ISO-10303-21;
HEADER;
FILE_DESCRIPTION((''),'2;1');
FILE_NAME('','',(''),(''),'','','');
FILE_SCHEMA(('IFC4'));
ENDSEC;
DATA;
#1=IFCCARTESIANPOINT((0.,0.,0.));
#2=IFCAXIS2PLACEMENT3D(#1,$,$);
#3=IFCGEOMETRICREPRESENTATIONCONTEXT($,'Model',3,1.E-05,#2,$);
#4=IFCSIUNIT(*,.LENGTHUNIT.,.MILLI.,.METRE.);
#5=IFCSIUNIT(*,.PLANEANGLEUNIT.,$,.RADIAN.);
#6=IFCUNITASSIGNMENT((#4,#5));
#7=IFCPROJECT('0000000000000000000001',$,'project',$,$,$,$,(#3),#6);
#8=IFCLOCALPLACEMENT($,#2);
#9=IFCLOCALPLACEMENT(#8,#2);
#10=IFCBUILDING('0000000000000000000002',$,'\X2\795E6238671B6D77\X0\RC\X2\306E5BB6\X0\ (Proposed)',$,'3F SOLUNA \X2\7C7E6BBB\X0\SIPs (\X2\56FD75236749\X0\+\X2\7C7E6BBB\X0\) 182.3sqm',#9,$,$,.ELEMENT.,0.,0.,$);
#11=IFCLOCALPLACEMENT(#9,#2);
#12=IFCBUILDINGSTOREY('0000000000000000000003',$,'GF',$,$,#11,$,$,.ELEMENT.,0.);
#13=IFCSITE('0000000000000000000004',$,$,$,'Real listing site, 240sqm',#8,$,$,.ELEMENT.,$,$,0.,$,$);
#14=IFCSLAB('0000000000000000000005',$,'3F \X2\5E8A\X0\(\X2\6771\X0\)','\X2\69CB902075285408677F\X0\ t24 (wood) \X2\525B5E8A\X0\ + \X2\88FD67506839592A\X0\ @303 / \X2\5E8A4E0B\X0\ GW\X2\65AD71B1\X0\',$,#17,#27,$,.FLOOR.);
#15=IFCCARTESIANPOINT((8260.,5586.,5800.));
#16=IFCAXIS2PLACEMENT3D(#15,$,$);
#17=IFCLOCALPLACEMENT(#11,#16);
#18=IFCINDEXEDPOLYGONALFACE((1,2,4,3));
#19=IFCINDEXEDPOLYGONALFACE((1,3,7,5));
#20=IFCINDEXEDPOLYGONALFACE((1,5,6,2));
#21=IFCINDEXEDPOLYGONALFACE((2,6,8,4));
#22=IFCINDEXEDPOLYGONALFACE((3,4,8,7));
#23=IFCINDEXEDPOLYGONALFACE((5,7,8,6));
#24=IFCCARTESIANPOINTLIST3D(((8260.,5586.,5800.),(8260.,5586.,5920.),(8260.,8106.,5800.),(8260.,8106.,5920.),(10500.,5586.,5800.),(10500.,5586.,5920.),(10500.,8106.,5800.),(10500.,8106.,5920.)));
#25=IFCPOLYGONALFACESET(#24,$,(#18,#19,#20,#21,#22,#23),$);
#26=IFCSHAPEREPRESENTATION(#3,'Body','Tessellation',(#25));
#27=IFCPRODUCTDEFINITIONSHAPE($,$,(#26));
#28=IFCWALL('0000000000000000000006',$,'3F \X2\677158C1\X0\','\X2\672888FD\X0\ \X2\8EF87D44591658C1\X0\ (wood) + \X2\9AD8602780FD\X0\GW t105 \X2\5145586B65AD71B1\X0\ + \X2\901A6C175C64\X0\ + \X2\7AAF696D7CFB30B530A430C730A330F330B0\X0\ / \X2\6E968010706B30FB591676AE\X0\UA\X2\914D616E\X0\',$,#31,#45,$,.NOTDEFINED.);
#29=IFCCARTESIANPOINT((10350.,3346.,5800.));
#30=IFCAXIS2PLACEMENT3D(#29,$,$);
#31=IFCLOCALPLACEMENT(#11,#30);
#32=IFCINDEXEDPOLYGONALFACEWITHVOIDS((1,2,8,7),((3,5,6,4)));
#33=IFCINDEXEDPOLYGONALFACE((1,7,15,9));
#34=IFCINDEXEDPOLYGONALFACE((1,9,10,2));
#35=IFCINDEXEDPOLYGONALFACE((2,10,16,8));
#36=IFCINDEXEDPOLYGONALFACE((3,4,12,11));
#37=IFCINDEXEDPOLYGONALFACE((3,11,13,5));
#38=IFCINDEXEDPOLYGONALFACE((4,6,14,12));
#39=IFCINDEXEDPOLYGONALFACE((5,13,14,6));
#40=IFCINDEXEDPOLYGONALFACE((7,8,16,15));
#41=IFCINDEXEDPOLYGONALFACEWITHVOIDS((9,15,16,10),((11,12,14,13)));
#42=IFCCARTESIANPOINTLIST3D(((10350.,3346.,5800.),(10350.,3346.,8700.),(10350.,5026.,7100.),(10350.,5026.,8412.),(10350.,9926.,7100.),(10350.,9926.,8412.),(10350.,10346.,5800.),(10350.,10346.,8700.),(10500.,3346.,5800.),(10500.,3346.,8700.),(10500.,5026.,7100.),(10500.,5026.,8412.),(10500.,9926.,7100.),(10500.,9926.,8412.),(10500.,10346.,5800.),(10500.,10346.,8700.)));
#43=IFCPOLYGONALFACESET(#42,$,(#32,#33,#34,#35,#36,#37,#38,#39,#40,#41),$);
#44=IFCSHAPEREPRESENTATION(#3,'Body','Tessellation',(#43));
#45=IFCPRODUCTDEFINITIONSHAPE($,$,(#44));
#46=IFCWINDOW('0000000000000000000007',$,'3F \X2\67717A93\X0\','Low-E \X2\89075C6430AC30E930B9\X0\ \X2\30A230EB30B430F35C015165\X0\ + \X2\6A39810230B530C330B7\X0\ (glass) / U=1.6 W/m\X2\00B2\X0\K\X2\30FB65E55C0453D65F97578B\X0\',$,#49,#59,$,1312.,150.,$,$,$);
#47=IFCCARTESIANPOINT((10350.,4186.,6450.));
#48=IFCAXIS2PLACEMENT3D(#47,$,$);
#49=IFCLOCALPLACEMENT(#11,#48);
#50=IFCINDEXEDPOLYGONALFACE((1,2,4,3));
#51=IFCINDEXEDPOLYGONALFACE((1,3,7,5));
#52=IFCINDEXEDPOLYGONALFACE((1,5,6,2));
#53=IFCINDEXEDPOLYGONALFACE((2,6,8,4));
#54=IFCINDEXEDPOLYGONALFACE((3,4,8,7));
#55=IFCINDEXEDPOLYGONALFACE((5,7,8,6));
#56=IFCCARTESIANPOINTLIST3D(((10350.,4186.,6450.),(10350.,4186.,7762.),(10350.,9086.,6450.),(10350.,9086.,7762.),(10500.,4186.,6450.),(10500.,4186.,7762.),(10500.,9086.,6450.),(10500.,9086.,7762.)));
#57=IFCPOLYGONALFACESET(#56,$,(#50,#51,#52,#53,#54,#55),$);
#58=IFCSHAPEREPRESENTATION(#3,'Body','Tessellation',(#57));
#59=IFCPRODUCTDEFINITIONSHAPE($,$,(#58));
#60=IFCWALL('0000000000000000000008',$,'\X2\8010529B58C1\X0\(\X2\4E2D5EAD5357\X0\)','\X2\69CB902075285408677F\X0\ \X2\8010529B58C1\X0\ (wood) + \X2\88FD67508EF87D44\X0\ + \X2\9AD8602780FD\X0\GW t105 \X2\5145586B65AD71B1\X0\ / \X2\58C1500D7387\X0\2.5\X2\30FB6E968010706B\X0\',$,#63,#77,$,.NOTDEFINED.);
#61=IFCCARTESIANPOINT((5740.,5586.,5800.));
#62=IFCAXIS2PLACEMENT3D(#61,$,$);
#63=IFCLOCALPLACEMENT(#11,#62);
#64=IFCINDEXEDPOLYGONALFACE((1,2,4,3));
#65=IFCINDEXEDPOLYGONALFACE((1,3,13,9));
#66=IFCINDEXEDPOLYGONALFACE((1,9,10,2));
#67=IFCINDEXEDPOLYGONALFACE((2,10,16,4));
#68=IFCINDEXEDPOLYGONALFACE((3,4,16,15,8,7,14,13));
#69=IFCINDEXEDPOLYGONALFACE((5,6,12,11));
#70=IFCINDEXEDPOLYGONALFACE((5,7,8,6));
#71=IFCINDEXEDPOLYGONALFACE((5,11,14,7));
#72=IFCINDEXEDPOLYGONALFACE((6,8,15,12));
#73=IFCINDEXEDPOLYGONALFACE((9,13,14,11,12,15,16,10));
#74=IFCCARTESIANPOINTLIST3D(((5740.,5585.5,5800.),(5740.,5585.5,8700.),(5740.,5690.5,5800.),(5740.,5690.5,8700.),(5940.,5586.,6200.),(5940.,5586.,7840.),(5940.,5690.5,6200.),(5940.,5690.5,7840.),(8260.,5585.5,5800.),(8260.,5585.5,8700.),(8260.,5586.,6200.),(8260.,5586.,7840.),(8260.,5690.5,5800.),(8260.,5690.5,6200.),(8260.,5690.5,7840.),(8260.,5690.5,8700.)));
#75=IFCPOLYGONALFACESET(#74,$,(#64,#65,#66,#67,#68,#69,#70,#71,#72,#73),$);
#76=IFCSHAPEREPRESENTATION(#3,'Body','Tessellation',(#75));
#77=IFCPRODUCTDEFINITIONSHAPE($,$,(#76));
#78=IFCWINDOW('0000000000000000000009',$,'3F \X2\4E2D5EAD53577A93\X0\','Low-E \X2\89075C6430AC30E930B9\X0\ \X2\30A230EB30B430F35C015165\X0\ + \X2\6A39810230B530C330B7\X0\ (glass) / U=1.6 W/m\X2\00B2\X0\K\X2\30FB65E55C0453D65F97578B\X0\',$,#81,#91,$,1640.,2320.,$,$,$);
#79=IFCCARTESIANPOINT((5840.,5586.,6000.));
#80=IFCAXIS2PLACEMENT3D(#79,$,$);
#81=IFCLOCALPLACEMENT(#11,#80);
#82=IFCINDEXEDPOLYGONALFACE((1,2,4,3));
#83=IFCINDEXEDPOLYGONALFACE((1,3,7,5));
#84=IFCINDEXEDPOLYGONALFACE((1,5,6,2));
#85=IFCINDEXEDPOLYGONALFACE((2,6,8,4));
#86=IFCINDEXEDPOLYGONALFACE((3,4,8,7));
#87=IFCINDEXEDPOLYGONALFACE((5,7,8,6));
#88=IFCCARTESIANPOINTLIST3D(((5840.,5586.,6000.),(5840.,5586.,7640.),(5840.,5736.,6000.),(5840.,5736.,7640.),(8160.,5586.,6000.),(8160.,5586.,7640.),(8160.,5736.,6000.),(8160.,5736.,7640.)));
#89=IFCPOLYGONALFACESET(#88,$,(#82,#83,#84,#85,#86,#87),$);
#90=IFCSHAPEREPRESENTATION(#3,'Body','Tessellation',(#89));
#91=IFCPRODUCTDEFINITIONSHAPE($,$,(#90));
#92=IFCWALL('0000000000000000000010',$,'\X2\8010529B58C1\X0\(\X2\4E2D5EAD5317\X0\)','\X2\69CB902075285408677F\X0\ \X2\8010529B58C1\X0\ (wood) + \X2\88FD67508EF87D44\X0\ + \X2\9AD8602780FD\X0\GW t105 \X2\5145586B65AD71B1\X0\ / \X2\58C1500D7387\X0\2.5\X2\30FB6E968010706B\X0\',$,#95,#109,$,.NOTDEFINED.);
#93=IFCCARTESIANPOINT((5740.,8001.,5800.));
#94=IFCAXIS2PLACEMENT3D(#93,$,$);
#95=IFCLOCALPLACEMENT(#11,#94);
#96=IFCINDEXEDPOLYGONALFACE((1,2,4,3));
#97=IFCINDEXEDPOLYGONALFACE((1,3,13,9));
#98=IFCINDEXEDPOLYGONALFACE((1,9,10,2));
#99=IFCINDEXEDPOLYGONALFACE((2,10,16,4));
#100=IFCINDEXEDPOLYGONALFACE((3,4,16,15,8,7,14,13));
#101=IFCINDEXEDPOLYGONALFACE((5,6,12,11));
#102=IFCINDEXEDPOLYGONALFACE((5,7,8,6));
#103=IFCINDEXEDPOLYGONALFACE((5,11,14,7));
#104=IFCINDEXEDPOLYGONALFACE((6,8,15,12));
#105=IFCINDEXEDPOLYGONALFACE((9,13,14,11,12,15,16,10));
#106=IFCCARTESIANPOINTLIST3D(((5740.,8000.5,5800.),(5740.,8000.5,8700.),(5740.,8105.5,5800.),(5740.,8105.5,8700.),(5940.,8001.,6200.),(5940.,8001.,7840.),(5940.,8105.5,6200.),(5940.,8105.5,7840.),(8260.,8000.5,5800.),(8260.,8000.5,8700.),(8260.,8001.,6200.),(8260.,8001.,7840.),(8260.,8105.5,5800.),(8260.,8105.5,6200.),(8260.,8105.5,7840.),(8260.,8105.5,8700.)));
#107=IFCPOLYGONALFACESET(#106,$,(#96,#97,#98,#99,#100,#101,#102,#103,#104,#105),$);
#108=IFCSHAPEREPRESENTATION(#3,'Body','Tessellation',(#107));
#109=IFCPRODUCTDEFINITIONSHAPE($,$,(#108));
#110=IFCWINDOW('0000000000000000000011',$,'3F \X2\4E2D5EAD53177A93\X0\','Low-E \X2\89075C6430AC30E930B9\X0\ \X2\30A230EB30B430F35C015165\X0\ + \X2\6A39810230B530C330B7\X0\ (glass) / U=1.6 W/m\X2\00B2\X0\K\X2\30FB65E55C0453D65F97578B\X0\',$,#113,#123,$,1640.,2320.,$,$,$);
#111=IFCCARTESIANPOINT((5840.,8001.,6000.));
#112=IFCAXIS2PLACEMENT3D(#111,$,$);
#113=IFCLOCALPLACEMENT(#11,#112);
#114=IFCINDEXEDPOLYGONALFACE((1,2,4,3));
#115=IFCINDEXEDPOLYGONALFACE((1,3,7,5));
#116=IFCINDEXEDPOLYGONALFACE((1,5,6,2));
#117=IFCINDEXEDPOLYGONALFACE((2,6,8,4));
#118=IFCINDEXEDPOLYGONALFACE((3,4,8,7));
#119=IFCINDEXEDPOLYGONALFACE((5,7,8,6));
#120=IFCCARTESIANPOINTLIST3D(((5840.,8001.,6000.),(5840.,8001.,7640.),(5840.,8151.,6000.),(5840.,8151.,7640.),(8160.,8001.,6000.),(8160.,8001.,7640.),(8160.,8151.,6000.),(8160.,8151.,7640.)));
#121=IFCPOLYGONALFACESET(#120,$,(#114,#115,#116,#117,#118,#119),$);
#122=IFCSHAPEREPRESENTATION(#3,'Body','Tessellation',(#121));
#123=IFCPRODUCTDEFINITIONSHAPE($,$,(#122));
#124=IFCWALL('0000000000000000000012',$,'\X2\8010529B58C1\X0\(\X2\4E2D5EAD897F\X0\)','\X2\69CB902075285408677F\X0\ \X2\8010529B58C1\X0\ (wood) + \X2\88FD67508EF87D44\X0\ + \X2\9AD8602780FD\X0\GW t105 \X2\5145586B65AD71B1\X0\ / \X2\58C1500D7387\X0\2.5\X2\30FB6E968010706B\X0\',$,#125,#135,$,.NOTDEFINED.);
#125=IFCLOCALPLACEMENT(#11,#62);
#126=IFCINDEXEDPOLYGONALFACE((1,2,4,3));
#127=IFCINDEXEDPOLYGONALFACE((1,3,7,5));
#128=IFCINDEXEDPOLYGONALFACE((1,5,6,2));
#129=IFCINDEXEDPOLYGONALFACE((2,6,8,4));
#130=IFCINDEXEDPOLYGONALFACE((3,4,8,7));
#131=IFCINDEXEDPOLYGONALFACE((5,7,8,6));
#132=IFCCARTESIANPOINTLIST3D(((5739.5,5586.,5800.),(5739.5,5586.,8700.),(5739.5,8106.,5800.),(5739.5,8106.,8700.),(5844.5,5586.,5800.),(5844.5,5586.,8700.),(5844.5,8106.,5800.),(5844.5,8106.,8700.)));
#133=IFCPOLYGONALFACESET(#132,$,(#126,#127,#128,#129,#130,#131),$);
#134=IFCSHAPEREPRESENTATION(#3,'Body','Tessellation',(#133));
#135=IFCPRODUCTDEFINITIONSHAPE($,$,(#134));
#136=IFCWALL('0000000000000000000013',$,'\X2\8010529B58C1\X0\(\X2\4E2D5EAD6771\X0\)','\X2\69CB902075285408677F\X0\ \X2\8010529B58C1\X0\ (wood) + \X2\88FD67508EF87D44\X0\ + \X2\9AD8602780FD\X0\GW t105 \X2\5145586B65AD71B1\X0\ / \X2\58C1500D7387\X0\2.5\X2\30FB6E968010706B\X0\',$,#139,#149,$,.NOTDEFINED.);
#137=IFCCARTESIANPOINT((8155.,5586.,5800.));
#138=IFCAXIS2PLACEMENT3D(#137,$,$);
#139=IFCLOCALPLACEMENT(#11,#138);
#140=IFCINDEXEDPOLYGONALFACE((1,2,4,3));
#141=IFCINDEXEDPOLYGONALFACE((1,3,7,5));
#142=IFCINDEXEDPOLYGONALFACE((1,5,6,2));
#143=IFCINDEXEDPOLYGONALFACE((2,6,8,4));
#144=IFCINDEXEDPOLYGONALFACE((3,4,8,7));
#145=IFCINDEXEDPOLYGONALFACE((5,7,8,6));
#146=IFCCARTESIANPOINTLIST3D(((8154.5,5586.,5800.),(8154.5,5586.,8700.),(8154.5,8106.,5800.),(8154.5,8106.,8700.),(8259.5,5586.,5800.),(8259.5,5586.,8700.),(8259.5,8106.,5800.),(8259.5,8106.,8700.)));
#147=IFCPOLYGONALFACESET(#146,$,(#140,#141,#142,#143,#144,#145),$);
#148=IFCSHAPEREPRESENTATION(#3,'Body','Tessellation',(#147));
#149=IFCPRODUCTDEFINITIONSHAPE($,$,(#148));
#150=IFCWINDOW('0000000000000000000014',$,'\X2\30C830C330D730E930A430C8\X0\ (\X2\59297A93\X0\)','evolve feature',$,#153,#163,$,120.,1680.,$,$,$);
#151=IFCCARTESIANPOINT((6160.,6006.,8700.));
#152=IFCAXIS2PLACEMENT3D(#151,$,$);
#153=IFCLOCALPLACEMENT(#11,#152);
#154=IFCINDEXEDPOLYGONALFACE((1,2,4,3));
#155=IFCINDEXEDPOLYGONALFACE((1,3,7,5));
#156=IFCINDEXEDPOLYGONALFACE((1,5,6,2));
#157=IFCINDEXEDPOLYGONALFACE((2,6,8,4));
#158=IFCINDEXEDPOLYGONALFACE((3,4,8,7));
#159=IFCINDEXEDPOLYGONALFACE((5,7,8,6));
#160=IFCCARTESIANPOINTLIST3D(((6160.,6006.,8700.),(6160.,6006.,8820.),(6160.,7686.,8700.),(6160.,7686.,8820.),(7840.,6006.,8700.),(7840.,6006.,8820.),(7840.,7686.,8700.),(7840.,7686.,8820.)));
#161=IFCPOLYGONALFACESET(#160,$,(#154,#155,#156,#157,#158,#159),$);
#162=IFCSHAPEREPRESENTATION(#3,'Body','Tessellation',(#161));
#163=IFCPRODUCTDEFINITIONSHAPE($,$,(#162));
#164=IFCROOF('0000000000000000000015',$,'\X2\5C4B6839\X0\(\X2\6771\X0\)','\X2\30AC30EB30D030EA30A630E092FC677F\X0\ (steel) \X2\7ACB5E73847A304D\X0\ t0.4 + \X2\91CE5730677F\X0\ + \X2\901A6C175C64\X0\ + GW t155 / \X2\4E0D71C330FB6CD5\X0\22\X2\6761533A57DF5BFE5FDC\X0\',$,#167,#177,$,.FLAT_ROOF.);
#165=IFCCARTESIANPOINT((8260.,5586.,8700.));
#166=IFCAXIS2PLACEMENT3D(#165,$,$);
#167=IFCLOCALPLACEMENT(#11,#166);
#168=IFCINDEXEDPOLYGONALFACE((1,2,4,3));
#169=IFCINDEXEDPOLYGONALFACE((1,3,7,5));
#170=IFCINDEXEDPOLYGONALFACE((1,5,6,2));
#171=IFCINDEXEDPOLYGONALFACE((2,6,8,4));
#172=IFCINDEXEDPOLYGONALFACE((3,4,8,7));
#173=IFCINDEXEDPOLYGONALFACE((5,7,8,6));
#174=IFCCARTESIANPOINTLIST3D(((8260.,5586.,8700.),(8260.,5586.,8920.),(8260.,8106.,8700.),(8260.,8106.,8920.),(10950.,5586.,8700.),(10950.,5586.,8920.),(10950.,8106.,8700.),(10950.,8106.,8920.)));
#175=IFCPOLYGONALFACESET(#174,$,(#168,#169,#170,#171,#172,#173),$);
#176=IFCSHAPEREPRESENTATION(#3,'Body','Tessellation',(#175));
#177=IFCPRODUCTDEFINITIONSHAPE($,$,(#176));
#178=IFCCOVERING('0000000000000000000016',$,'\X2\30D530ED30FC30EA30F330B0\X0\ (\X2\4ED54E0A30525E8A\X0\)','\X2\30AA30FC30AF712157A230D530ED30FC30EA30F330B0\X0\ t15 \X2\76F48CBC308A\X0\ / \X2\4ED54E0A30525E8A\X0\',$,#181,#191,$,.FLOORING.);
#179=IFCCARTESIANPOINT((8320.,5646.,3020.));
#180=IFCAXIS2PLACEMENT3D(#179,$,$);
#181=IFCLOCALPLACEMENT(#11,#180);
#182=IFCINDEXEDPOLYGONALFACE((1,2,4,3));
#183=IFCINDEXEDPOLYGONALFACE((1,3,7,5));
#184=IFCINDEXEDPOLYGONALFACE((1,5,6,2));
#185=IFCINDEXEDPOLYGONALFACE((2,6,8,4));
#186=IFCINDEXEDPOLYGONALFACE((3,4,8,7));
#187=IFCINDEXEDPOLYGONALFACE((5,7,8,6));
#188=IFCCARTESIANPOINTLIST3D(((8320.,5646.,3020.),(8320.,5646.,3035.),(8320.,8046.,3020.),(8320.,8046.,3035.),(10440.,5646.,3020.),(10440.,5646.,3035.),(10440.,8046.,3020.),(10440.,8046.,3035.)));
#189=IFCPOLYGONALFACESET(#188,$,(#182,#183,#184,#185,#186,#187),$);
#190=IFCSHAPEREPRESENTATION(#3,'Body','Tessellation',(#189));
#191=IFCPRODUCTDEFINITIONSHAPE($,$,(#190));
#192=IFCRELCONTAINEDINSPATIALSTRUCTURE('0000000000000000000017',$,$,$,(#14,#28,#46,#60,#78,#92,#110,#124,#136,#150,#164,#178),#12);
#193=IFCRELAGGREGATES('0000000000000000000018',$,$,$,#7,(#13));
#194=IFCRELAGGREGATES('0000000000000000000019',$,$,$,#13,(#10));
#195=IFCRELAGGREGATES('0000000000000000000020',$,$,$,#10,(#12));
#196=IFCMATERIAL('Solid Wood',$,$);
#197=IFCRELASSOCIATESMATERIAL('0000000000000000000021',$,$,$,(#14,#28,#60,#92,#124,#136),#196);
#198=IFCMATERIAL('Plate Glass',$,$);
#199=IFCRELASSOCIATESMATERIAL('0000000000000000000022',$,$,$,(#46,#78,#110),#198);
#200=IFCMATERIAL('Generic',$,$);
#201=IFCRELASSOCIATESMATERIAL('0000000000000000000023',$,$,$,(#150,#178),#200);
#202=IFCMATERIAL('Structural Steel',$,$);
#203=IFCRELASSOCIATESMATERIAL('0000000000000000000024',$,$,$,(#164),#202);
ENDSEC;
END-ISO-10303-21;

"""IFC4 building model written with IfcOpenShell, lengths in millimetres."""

from ifc_helpers import new_model, si_unit, frame, frame_2d, origin, place, context, project, spatial, rectangle, extrude, material, element, fill, save


model = new_model("IFC4")

# Units and contexts
model_context = context("Model", 3, precision=1e-05, world=origin())
ifc_project = project(units=[si_unit("LENGTHUNIT", "METRE", prefix="MILLI"), si_unit("PLANEANGLEUNIT", "RADIAN")], contexts=[model_context])

# Site, building, storey
site_placement = place(None, origin())
site = spatial("IfcSite", under=ifc_project, at=site_placement, ObjectType="Real listing site, 240sqm", CompositionType="ELEMENT", RefElevation=0.0)
building_placement = place(site_placement, origin())
building = spatial("IfcBuilding", under=site, at=building_placement, Name="神戸望海RCの家 (Proposed)", ObjectType="3F SOLUNA 籾殻SIPs (国産杉+籾殻) 182.3sqm", CompositionType="ELEMENT", ElevationOfRefHeight=0.0, ElevationOfTerrain=0.0)
storey_placement = place(building_placement, origin())
storey = spatial("IfcBuildingStorey", under=building, at=storey_placement, Name="GF", CompositionType="ELEMENT", Elevation=0.0)

# Slab
ifc_material_1 = material(Name="Solid Wood")
slab_placement = place(storey_placement, frame((8260.0, 5586.0, 5800.0)))
element("IfcSlab", 1, at=slab_placement, inside=storey, material=ifc_material_1, Name="3F 床(東)", Description="構造用合板 t24 (wood) 剛床 + 製材根太 @303 / 床下 GW断熱", PredefinedType="FLOOR", context=model_context, shape_type="SweptSolid", body=[
    extrude(rectangle(XDim=2240.0, YDim=2520.0, at=frame_2d((1120.0, 1260.0))), frame((8260.0, 5586.0, 5800.0)), (0.0, 0.0, 1.0), 120.0),
])

# Walls, openings, windows
wall_1_placement = place(storey_placement, frame((10350.0, 3346.0, 5800.0)))
wall_1 = element("IfcWall", 2, at=wall_1_placement, inside=storey, material=ifc_material_1, Name="3F 東壁", Description="木製 軸組外壁 (wood) + 高性能GW t105 充填断熱 + 通気層 + 窯業系サイディング / 準耐火・外皮UA配慮", PredefinedType="NOTDEFINED", context=model_context, shape_type="SweptSolid", body=[
    extrude(rectangle(XDim=150.0, YDim=7000.0, at=frame_2d((75.0, 3500.0))), frame((10350.0, 3346.0, 5800.0)), (0.0, 0.0, 1.0), 2900.0),
])
opening_1_placement = place(storey_placement, frame((10350.0, 4186.0, 6450.0)))
opening_1 = element("IfcOpeningElement", 3, at=opening_1_placement, cuts=wall_1, PredefinedType="NOTDEFINED", context=model_context, shape_type="SweptSolid", body=[
    extrude(rectangle(XDim=150.0, YDim=4900.0, at=frame_2d((75.0, 2450.0))), frame((10350.0, 4186.0, 6450.0)), (0.0, 0.0, 1.0), 1312.0),
])
ifc_material_2 = material(Name="Plate Glass")
window_1_placement = place(storey_placement, frame((10350.0, 4186.0, 6450.0)))
window_1 = element("IfcWindow", 4, at=window_1_placement, inside=storey, material=ifc_material_2, Name="3F 東窓", Description="Low-E 複層ガラス アルゴン封入 + 樹脂サッシ (glass) / U=1.6 W/m²K・日射取得型", OverallHeight=1312.0, OverallWidth=150.0, context=model_context, shape_type="SweptSolid", body=[
    extrude(rectangle(XDim=150.0, YDim=4900.0, at=frame_2d((75.0, 2450.0))), frame((10350.0, 4186.0, 6450.0)), (0.0, 0.0, 1.0), 1312.0),
])
fill(opening_1, window_1)
wall_2_placement = place(storey_placement, frame((5740.0, 5586.0, 5800.0)))
wall_2 = element("IfcWall", 5, at=wall_2_placement, inside=storey, material=ifc_material_1, Name="耐力壁(中庭南)", Description="構造用合板 耐力壁 (wood) + 製材軸組 + 高性能GW t105 充填断熱 / 壁倍率2.5・準耐火", PredefinedType="NOTDEFINED", context=model_context, shape_type="SweptSolid", body=[
    extrude(rectangle(XDim=2520.0, YDim=105.0, at=frame_2d((1260.0, 52.0))), frame((5740.0, 5586.0, 5800.0)), (0.0, 0.0, 1.0), 2900.0),
])
opening_2_placement = place(storey_placement, frame((5840.0, 5586.0, 6000.0)))
opening_2 = element("IfcOpeningElement", 6, at=opening_2_placement, cuts=wall_2, PredefinedType="NOTDEFINED", context=model_context, shape_type="SweptSolid", body=[
    extrude(rectangle(XDim=2320.0, YDim=150.0, at=frame_2d((1160.0, 75.0))), frame((5840.0, 5586.0, 6000.0)), (0.0, 0.0, 1.0), 1640.0),
])
window_2_placement = place(storey_placement, frame((5840.0, 5586.0, 6000.0)))
window_2 = element("IfcWindow", 7, at=window_2_placement, inside=storey, material=ifc_material_2, Name="3F 中庭南窓", Description="Low-E 複層ガラス アルゴン封入 + 樹脂サッシ (glass) / U=1.6 W/m²K・日射取得型", OverallHeight=1640.0, OverallWidth=2320.0, context=model_context, shape_type="SweptSolid", body=[
    extrude(rectangle(XDim=2320.0, YDim=150.0, at=frame_2d((1160.0, 75.0))), frame((5840.0, 5586.0, 6000.0)), (0.0, 0.0, 1.0), 1640.0),
])
fill(opening_2, window_2)
wall_3_placement = place(storey_placement, frame((5740.0, 8001.0, 5800.0)))
wall_3 = element("IfcWall", 8, at=wall_3_placement, inside=storey, material=ifc_material_1, Name="耐力壁(中庭北)", Description="構造用合板 耐力壁 (wood) + 製材軸組 + 高性能GW t105 充填断熱 / 壁倍率2.5・準耐火", PredefinedType="NOTDEFINED", context=model_context, shape_type="SweptSolid", body=[
    extrude(rectangle(XDim=2520.0, YDim=105.0, at=frame_2d((1260.0, 52.0))), frame((5740.0, 8001.0, 5800.0)), (0.0, 0.0, 1.0), 2900.0),
])
opening_3_placement = place(storey_placement, frame((5840.0, 8001.0, 6000.0)))
opening_3 = element("IfcOpeningElement", 9, at=opening_3_placement, cuts=wall_3, PredefinedType="NOTDEFINED", context=model_context, shape_type="SweptSolid", body=[
    extrude(rectangle(XDim=2320.0, YDim=150.0, at=frame_2d((1160.0, 75.0))), frame((5840.0, 8001.0, 6000.0)), (0.0, 0.0, 1.0), 1640.0),
])
window_3_placement = place(storey_placement, frame((5840.0, 8001.0, 6000.0)))
window_3 = element("IfcWindow", 10, at=window_3_placement, inside=storey, material=ifc_material_2, Name="3F 中庭北窓", Description="Low-E 複層ガラス アルゴン封入 + 樹脂サッシ (glass) / U=1.6 W/m²K・日射取得型", OverallHeight=1640.0, OverallWidth=2320.0, context=model_context, shape_type="SweptSolid", body=[
    extrude(rectangle(XDim=2320.0, YDim=150.0, at=frame_2d((1160.0, 75.0))), frame((5840.0, 8001.0, 6000.0)), (0.0, 0.0, 1.0), 1640.0),
])
fill(opening_3, window_3)

# Walls
wall_4_placement = place(storey_placement, frame((5740.0, 5586.0, 5800.0)))
element("IfcWall", 11, at=wall_4_placement, inside=storey, material=ifc_material_1, Name="耐力壁(中庭西)", Description="構造用合板 耐力壁 (wood) + 製材軸組 + 高性能GW t105 充填断熱 / 壁倍率2.5・準耐火", PredefinedType="NOTDEFINED", context=model_context, shape_type="SweptSolid", body=[
    extrude(rectangle(XDim=105.0, YDim=2520.0, at=frame_2d((52.0, 1260.0))), frame((5740.0, 5586.0, 5800.0)), (0.0, 0.0, 1.0), 2900.0),
])
wall_5_placement = place(storey_placement, frame((8155.0, 5586.0, 5800.0)))
element("IfcWall", 12, at=wall_5_placement, inside=storey, material=ifc_material_1, Name="耐力壁(中庭東)", Description="構造用合板 耐力壁 (wood) + 製材軸組 + 高性能GW t105 充填断熱 / 壁倍率2.5・準耐火", PredefinedType="NOTDEFINED", context=model_context, shape_type="SweptSolid", body=[
    extrude(rectangle(XDim=105.0, YDim=2520.0, at=frame_2d((52.0, 1260.0))), frame((8155.0, 5586.0, 5800.0)), (0.0, 0.0, 1.0), 2900.0),
])

# Window
ifc_material_3 = material(Name="Generic")
window_4_placement = place(storey_placement, frame((6160.0, 6006.0, 8700.0)))
element("IfcWindow", 13, at=window_4_placement, inside=storey, material=ifc_material_3, Name="トップライト (天窓)", Description="evolve feature", OverallHeight=120.0, OverallWidth=1680.0, context=model_context, shape_type="SweptSolid", body=[
    extrude(rectangle(XDim=1680.0, YDim=1680.0, at=frame_2d((840.0, 840.0))), frame((6160.0, 6006.0, 8700.0)), (0.0, 0.0, 1.0), 120.0),
])

# Roof
ifc_material_4 = material(Name="Structural Steel")
for number, where, name in (
    (14, (8260.0, 5586.0, 8700.0), "屋根(東)"),
):
    element("IfcRoof", number, at=place(storey_placement, frame(where)), inside=storey, material=ifc_material_4, Name=name, Description="ガルバリウム鋼板 (steel) 立平葺き t0.4 + 野地板 + 通気層 + GW t155 / 不燃・法22条区域対応", PredefinedType="FLAT_ROOF", context=model_context, shape_type="SweptSolid", body=[
        extrude(rectangle(XDim=2690.0, YDim=2520.0, at=frame_2d((1345.0, 1260.0))), frame((8260.0, 5586.0, 8700.0)), (0.0, 0.0, 1.0), 220.0),
    ])

# Covering
covering_1_placement = place(storey_placement, frame((8320.0, 5646.0, 3020.0)))
element("IfcCovering", 15, at=covering_1_placement, inside=storey, material=ifc_material_3, Name="フローリング (仕上げ床)", Description="オーク無垢フローリング t15 直貼り / 仕上げ床", PredefinedType="FLOORING", context=model_context, shape_type="SweptSolid", body=[
    extrude(rectangle(XDim=2120.0, YDim=2400.0, at=frame_2d((1060.0, 1200.0))), frame((8320.0, 5646.0, 3020.0)), (0.0, 0.0, 1.0), 15.0),
])

save(model, "model.ifc")
